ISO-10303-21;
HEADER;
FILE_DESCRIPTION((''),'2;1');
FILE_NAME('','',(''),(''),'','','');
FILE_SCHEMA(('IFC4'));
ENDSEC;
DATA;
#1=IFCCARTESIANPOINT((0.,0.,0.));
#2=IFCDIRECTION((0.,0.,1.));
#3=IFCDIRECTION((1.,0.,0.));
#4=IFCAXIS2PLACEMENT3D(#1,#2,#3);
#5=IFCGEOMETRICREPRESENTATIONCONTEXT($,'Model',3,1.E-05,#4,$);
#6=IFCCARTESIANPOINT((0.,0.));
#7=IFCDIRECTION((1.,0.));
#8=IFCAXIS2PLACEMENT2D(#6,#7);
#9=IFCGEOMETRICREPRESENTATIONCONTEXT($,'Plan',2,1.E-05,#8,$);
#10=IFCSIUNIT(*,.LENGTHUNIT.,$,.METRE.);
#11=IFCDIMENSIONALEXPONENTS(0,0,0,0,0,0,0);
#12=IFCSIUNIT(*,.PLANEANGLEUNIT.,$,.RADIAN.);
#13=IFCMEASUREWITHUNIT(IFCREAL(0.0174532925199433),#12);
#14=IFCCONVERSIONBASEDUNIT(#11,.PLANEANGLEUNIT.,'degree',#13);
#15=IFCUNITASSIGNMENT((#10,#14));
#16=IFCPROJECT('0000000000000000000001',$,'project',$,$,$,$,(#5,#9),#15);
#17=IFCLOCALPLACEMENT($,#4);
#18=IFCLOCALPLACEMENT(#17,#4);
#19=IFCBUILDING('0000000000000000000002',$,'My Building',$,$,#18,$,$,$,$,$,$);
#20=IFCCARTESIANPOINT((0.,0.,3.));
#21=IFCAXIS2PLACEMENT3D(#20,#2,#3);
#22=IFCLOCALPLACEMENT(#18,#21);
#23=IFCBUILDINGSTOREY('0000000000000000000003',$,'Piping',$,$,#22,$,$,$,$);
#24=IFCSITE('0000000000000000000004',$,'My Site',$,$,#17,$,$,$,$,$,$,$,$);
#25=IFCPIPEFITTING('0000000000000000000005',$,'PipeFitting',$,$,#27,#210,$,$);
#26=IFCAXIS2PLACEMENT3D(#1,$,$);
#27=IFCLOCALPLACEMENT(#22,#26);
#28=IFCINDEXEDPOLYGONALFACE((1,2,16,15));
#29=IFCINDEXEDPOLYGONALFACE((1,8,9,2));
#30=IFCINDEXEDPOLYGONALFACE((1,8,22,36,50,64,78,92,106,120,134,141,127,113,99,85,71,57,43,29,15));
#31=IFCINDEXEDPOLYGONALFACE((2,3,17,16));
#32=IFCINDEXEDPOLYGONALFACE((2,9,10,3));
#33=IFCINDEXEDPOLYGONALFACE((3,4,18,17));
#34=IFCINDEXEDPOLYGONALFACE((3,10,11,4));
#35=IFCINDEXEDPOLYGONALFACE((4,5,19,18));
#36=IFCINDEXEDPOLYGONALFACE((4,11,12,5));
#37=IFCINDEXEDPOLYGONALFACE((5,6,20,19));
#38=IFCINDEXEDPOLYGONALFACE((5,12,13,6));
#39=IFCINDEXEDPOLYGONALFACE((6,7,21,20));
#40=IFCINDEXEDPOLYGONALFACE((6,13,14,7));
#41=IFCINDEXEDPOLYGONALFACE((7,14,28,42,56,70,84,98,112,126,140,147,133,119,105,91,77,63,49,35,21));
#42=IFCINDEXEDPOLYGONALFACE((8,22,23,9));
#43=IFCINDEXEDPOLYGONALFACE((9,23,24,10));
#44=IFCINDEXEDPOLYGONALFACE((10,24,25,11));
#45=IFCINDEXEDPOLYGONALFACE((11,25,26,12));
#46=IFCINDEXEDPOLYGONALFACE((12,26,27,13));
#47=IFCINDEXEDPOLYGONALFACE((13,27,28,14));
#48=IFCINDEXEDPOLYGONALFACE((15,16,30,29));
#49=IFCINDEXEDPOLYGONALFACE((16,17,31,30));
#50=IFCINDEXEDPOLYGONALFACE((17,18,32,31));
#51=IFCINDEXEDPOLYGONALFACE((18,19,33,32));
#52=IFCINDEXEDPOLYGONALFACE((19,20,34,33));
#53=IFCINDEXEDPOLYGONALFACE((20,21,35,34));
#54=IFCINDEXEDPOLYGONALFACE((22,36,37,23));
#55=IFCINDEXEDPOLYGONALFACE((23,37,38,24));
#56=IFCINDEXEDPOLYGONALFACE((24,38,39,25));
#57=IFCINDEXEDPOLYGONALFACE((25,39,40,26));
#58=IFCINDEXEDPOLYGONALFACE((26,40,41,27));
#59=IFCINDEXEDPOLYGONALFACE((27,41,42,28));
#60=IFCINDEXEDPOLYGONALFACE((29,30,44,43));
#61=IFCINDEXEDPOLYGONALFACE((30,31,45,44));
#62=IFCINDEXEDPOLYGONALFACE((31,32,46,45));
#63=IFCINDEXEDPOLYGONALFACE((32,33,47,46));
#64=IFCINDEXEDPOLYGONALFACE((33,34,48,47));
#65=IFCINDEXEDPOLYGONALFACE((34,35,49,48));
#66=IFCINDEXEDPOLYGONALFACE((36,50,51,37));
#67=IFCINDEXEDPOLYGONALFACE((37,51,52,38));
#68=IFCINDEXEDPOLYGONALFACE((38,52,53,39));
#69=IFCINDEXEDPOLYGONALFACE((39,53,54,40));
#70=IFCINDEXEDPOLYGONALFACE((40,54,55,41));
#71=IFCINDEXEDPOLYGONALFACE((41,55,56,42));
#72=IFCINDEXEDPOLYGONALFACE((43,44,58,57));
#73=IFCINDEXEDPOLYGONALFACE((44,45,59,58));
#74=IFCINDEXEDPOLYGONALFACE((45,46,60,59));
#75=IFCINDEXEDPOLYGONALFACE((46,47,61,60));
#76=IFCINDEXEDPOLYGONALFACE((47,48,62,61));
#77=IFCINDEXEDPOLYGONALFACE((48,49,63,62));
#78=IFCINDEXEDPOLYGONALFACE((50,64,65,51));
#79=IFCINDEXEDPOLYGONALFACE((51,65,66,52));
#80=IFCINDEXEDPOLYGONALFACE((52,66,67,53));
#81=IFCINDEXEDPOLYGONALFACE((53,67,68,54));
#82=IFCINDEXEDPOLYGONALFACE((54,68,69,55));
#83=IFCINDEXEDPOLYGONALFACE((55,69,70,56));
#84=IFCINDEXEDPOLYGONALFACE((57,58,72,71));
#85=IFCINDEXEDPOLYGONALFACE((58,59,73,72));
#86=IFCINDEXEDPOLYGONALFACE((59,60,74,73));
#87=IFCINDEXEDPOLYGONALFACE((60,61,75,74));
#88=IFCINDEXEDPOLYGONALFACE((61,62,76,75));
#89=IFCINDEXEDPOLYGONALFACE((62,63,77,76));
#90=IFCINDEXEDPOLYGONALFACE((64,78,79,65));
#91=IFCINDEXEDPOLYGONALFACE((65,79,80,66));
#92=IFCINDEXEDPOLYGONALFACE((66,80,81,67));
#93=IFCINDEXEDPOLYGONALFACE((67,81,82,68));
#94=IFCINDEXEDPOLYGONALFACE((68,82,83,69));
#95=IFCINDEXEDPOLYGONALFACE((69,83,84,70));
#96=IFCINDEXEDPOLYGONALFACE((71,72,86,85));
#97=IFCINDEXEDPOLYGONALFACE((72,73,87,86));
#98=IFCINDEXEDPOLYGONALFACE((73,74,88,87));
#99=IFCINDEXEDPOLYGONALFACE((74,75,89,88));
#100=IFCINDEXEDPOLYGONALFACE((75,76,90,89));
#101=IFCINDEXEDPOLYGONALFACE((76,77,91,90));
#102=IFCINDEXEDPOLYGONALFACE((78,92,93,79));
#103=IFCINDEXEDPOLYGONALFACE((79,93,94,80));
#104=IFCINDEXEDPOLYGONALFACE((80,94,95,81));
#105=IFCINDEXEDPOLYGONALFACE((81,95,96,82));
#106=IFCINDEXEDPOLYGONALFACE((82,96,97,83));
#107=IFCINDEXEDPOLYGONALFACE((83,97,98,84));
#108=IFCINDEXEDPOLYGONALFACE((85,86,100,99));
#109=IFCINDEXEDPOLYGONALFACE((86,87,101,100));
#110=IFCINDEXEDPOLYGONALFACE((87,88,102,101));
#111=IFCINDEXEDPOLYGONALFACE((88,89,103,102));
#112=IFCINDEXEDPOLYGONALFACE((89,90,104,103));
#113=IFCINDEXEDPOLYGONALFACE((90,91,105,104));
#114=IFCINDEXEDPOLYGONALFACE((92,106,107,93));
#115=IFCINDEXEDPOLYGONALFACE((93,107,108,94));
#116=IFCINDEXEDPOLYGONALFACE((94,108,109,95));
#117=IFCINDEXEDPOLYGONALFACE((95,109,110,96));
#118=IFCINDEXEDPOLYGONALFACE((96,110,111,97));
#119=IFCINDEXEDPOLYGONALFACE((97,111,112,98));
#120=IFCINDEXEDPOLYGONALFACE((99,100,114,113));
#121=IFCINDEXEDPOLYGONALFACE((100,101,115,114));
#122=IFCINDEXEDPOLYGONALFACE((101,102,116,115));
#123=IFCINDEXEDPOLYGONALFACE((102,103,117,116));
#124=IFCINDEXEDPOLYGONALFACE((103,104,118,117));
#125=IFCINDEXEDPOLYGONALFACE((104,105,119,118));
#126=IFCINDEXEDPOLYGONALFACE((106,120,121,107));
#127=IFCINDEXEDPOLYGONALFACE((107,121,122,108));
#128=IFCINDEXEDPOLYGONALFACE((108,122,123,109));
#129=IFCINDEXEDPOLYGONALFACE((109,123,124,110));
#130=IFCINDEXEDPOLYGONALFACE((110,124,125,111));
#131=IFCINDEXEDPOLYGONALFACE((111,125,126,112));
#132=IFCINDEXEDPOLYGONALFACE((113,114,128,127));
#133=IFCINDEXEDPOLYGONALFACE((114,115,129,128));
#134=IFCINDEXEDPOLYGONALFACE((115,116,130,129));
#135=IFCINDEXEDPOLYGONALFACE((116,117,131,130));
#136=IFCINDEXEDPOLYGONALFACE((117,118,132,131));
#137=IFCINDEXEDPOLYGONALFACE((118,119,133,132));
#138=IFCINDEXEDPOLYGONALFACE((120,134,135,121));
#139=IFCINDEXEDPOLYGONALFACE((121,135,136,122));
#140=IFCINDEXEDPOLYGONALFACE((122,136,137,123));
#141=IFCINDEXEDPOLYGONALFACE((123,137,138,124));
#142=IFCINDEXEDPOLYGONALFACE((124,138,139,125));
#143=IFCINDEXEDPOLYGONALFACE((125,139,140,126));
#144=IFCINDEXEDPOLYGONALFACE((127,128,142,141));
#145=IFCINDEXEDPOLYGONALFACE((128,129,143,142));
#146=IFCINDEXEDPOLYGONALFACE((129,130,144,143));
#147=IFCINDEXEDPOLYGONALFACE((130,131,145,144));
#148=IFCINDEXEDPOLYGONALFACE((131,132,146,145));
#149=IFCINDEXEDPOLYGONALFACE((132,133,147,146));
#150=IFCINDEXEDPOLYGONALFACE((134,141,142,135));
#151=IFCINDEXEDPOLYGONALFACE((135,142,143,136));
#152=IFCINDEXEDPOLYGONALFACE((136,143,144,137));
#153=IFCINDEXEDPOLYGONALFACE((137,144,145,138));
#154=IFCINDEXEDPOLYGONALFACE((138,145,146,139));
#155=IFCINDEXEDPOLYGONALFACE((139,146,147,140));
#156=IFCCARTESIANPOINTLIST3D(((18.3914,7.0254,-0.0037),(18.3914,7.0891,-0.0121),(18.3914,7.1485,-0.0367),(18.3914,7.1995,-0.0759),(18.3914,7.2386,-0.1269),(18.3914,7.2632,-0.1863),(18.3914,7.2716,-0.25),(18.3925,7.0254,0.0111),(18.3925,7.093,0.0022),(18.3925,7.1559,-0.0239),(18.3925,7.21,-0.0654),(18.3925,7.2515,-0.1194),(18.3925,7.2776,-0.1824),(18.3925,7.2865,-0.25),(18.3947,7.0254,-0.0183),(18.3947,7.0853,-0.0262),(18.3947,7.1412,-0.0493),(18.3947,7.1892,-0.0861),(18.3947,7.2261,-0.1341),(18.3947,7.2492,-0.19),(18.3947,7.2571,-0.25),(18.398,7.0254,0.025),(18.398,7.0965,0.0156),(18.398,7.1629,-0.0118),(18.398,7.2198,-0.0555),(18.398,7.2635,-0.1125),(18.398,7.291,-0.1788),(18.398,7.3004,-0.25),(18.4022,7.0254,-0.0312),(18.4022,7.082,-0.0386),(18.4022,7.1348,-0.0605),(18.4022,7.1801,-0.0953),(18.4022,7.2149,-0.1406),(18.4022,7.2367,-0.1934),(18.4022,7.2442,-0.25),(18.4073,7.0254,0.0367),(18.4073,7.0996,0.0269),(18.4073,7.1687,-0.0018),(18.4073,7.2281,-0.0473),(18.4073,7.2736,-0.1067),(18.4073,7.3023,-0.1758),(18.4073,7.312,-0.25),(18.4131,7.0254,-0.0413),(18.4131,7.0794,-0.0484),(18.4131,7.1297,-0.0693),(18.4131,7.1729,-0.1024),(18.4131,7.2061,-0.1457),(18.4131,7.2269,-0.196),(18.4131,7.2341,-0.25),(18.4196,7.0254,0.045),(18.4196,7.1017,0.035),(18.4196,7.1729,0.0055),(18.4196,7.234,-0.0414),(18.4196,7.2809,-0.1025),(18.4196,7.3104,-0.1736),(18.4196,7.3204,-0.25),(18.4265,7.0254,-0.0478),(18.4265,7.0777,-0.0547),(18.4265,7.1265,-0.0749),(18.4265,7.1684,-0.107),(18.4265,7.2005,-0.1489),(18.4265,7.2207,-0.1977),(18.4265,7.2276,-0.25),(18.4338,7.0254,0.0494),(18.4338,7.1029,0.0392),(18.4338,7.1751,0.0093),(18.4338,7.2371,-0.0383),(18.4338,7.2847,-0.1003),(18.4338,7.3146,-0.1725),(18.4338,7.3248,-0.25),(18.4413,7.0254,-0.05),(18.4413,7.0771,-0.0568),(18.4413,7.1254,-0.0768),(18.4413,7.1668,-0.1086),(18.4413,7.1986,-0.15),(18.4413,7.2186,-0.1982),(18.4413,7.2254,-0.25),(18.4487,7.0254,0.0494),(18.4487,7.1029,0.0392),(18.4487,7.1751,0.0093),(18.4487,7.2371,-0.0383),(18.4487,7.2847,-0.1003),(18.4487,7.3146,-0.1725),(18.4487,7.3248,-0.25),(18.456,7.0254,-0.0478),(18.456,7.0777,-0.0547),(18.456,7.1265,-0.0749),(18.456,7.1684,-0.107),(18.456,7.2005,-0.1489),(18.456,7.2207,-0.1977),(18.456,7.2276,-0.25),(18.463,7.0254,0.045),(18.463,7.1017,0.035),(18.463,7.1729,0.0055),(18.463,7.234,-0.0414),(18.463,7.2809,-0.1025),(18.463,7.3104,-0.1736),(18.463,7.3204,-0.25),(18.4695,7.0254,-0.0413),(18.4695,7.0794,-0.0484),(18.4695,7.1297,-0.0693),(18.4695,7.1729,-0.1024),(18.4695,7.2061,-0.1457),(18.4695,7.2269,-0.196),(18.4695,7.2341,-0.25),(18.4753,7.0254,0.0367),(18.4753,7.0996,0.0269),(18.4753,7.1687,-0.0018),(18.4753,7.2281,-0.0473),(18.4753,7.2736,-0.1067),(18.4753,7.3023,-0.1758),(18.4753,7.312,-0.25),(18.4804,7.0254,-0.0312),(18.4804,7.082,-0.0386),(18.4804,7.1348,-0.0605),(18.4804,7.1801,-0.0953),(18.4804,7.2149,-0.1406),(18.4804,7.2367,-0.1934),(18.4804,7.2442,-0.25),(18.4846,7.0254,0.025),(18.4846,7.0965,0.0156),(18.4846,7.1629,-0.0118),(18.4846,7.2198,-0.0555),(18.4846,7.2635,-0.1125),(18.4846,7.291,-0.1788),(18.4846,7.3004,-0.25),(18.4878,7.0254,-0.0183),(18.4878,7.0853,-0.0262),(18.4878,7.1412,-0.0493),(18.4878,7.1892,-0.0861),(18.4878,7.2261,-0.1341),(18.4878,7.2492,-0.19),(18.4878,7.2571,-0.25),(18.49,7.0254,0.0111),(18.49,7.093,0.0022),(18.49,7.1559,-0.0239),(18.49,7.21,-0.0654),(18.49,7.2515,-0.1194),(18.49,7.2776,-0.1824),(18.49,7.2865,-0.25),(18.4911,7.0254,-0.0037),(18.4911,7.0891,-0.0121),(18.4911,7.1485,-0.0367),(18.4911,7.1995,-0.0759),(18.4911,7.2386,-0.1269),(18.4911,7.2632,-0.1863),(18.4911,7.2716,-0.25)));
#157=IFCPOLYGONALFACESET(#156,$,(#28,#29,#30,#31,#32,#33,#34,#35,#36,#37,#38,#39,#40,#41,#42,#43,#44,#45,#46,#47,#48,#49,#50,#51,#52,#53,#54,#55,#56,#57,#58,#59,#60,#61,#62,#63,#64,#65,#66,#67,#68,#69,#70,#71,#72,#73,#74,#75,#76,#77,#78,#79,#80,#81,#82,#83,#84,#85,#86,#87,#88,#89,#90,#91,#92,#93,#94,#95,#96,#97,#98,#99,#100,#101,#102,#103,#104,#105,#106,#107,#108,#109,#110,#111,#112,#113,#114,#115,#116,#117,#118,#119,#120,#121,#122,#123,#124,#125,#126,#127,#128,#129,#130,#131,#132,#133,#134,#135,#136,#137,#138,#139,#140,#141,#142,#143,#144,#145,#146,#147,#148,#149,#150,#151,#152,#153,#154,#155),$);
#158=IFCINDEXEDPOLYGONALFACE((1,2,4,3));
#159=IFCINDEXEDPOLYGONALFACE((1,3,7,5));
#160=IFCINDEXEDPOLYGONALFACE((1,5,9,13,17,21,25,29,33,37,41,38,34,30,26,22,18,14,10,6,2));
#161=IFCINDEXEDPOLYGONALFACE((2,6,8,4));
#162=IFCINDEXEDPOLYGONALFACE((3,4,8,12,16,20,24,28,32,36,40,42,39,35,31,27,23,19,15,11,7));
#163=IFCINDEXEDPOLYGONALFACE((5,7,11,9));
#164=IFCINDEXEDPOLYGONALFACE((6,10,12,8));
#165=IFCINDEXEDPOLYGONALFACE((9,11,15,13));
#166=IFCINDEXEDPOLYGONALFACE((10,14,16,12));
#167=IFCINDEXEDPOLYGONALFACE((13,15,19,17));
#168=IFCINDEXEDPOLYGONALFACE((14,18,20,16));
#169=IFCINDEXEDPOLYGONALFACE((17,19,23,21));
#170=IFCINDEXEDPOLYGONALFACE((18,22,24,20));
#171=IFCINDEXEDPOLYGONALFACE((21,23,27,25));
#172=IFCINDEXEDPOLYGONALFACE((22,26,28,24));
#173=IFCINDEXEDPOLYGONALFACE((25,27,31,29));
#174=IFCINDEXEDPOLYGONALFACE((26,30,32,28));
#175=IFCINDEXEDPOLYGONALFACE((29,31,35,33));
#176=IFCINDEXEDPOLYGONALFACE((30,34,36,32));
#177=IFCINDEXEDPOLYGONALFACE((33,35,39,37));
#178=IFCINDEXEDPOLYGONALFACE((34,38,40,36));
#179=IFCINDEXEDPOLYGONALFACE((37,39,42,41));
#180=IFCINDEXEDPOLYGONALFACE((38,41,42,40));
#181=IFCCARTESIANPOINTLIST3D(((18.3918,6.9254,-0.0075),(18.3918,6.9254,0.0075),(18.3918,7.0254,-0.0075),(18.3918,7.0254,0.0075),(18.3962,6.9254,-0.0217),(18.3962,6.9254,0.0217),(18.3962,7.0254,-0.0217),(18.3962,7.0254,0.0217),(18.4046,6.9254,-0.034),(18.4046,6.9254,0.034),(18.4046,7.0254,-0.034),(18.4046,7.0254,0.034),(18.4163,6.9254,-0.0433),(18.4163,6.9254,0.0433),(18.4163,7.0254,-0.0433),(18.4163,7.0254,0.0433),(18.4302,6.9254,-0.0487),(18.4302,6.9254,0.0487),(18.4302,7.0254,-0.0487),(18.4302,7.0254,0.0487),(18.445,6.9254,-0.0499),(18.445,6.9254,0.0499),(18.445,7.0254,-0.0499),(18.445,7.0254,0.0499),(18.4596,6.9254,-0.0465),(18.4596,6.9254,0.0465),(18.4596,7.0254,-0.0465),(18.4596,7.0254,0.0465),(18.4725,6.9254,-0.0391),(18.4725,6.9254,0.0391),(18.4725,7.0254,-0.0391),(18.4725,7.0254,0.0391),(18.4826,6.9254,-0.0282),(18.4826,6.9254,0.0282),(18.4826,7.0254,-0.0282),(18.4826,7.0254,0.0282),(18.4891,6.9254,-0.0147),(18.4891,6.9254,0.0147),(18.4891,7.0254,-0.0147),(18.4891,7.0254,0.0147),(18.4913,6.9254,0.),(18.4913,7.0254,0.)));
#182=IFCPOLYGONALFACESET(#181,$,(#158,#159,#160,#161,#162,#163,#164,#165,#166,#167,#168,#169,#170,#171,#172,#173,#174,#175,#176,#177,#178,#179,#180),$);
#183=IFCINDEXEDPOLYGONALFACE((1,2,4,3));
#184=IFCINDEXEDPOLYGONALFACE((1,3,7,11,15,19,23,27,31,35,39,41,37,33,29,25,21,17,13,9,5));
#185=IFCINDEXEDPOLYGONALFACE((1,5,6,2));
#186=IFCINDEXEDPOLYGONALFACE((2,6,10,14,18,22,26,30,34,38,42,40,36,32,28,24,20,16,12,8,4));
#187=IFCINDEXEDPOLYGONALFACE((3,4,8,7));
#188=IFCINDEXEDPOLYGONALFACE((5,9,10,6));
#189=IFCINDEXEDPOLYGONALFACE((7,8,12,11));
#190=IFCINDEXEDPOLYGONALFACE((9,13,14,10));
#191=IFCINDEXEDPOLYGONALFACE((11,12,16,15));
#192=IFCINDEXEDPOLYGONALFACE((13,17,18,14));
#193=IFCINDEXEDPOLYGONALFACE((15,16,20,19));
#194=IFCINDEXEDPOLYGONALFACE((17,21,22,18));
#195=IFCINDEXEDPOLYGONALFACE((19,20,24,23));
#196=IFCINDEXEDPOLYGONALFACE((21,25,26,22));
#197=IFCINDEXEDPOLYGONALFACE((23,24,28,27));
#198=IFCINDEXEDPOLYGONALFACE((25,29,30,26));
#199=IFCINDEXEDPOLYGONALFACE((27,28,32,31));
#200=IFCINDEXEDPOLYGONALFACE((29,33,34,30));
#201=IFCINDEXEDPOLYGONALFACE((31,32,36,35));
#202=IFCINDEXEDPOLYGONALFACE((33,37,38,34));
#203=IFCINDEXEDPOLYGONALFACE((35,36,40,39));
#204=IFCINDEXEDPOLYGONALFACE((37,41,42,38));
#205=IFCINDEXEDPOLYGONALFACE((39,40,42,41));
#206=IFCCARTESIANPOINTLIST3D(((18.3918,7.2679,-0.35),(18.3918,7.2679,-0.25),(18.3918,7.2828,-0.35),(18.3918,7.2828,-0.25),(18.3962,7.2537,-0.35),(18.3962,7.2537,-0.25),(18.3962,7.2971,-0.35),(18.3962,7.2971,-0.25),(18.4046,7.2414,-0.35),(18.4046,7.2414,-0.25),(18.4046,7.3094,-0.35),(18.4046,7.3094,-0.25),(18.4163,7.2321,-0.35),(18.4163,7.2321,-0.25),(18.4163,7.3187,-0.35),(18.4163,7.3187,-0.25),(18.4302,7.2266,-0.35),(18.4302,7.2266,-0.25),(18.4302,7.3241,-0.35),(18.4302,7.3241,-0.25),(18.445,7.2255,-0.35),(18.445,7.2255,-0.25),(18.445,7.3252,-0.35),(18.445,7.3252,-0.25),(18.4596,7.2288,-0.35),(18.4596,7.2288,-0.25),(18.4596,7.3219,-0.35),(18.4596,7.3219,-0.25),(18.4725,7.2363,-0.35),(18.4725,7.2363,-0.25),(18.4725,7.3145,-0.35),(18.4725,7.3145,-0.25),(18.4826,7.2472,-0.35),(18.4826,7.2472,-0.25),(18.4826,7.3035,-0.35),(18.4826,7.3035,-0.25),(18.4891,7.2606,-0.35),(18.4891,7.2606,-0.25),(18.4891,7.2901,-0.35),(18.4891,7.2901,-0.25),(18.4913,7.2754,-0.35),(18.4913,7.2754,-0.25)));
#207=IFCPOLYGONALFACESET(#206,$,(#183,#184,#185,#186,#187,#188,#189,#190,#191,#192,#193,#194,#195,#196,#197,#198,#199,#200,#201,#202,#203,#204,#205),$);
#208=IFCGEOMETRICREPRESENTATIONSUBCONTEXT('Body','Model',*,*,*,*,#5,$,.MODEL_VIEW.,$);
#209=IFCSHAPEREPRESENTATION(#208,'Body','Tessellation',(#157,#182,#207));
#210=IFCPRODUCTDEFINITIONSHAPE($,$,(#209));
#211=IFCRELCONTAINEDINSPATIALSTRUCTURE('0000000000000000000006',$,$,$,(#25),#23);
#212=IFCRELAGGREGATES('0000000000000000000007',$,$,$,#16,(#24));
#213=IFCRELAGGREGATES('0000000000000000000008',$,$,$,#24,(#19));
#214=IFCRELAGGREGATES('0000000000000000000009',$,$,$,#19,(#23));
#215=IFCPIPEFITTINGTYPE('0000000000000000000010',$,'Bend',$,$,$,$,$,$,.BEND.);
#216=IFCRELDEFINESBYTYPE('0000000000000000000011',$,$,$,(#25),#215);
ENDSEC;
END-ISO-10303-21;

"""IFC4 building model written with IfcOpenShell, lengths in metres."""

from ifc_helpers import new_model, entity, si_unit, converted_unit, frame, origin_with_axes, origin_2d_with_axis, place, context, subcontext, project, spatial, circle, extrude, source, transform, mapped, type_object, type_shapes, element, save


model = new_model("IFC4")

# Units and contexts
model_context = context("Model", 3, precision=1e-05, world=origin_with_axes())
plan_context = context("Plan", 2, precision=1e-05, world=origin_2d_with_axis())
body_context = subcontext(model_context, "Body", "Model", "MODEL_VIEW")
ifc_project = project(units=[si_unit("LENGTHUNIT", "METRE"), converted_unit("PLANEANGLEUNIT", "degree", entity("IfcReal", 0.0174532925199433), si_unit("PLANEANGLEUNIT", "RADIAN"), dimensions=[0, 0, 0, 0, 0, 0, 0])], contexts=[model_context, plan_context])

# Site, building, storey
site_placement = place(None, origin_with_axes())
site = spatial("IfcSite", under=ifc_project, at=site_placement, Name="My Site")
building_placement = place(site_placement, origin_with_axes())
building = spatial("IfcBuilding", under=site, at=building_placement, Name="My Building")
storey_placement = place(building_placement, frame((0.0, 0.0, 3.0), z_axis=(0.0, 0.0, 1.0), x_axis=(1.0, 0.0, 0.0)))
storey = spatial("IfcBuildingStorey", under=building, at=storey_placement, Name="Piping")

# Pipe fitting
pipe_fitting_type = type_object("IfcPipeFittingType", Name="Bend", PredefinedType="BEND")
shared_shape = source(origin_with_axes(), body_context, "Body", "SolidModel", [
    entity("IfcSweptDiskSolid", entity("IfcIndexedPolyCurve", entity("IfcCartesianPointList3D", [[0.0, 0.0, -0.1], [0.0, -0.0732, -0.2768], [0.0, -0.25, -0.35]]), [entity("IfcArcIndex", [1, 2, 3])]), 0.05),
    extrude(circle(Radius=0.05), origin_with_axes(), (0.0, 0.0, -1.0), 0.1),
    extrude(circle(Radius=0.05), frame((0.0, -0.25, -0.35), z_axis=(0.0, -1.0, 0.0), x_axis=(1.0, 0.0, 0.0)), (0.0, 0.0, 1.0), 0.1),
])
type_shapes(pipe_fitting_type, [shared_shape])
for number, where, z_axis, x_axis, name in (
    (1, (18.4413, 6.9254, 0.0), (0.0, -1.0, 0.0), (1.0, 0.0, 0.0), "PipeFitting"),
):
    element("IfcPipeFitting", number, at=place(storey_placement, frame(where, z_axis=z_axis, x_axis=x_axis)), inside=storey, type_object=pipe_fitting_type, Name=name, context=body_context, shape_type="MappedRepresentation", body=[
        mapped(shared_shape, transform((0.0, 0.0, 0.0), x_axis=(1.0, 0.0, 0.0), y_axis=(0.0, 1.0, 0.0), z_axis=(0.0, 0.0, 1.0), scale=1.0)),
    ])

save(model, "model.ifc")
